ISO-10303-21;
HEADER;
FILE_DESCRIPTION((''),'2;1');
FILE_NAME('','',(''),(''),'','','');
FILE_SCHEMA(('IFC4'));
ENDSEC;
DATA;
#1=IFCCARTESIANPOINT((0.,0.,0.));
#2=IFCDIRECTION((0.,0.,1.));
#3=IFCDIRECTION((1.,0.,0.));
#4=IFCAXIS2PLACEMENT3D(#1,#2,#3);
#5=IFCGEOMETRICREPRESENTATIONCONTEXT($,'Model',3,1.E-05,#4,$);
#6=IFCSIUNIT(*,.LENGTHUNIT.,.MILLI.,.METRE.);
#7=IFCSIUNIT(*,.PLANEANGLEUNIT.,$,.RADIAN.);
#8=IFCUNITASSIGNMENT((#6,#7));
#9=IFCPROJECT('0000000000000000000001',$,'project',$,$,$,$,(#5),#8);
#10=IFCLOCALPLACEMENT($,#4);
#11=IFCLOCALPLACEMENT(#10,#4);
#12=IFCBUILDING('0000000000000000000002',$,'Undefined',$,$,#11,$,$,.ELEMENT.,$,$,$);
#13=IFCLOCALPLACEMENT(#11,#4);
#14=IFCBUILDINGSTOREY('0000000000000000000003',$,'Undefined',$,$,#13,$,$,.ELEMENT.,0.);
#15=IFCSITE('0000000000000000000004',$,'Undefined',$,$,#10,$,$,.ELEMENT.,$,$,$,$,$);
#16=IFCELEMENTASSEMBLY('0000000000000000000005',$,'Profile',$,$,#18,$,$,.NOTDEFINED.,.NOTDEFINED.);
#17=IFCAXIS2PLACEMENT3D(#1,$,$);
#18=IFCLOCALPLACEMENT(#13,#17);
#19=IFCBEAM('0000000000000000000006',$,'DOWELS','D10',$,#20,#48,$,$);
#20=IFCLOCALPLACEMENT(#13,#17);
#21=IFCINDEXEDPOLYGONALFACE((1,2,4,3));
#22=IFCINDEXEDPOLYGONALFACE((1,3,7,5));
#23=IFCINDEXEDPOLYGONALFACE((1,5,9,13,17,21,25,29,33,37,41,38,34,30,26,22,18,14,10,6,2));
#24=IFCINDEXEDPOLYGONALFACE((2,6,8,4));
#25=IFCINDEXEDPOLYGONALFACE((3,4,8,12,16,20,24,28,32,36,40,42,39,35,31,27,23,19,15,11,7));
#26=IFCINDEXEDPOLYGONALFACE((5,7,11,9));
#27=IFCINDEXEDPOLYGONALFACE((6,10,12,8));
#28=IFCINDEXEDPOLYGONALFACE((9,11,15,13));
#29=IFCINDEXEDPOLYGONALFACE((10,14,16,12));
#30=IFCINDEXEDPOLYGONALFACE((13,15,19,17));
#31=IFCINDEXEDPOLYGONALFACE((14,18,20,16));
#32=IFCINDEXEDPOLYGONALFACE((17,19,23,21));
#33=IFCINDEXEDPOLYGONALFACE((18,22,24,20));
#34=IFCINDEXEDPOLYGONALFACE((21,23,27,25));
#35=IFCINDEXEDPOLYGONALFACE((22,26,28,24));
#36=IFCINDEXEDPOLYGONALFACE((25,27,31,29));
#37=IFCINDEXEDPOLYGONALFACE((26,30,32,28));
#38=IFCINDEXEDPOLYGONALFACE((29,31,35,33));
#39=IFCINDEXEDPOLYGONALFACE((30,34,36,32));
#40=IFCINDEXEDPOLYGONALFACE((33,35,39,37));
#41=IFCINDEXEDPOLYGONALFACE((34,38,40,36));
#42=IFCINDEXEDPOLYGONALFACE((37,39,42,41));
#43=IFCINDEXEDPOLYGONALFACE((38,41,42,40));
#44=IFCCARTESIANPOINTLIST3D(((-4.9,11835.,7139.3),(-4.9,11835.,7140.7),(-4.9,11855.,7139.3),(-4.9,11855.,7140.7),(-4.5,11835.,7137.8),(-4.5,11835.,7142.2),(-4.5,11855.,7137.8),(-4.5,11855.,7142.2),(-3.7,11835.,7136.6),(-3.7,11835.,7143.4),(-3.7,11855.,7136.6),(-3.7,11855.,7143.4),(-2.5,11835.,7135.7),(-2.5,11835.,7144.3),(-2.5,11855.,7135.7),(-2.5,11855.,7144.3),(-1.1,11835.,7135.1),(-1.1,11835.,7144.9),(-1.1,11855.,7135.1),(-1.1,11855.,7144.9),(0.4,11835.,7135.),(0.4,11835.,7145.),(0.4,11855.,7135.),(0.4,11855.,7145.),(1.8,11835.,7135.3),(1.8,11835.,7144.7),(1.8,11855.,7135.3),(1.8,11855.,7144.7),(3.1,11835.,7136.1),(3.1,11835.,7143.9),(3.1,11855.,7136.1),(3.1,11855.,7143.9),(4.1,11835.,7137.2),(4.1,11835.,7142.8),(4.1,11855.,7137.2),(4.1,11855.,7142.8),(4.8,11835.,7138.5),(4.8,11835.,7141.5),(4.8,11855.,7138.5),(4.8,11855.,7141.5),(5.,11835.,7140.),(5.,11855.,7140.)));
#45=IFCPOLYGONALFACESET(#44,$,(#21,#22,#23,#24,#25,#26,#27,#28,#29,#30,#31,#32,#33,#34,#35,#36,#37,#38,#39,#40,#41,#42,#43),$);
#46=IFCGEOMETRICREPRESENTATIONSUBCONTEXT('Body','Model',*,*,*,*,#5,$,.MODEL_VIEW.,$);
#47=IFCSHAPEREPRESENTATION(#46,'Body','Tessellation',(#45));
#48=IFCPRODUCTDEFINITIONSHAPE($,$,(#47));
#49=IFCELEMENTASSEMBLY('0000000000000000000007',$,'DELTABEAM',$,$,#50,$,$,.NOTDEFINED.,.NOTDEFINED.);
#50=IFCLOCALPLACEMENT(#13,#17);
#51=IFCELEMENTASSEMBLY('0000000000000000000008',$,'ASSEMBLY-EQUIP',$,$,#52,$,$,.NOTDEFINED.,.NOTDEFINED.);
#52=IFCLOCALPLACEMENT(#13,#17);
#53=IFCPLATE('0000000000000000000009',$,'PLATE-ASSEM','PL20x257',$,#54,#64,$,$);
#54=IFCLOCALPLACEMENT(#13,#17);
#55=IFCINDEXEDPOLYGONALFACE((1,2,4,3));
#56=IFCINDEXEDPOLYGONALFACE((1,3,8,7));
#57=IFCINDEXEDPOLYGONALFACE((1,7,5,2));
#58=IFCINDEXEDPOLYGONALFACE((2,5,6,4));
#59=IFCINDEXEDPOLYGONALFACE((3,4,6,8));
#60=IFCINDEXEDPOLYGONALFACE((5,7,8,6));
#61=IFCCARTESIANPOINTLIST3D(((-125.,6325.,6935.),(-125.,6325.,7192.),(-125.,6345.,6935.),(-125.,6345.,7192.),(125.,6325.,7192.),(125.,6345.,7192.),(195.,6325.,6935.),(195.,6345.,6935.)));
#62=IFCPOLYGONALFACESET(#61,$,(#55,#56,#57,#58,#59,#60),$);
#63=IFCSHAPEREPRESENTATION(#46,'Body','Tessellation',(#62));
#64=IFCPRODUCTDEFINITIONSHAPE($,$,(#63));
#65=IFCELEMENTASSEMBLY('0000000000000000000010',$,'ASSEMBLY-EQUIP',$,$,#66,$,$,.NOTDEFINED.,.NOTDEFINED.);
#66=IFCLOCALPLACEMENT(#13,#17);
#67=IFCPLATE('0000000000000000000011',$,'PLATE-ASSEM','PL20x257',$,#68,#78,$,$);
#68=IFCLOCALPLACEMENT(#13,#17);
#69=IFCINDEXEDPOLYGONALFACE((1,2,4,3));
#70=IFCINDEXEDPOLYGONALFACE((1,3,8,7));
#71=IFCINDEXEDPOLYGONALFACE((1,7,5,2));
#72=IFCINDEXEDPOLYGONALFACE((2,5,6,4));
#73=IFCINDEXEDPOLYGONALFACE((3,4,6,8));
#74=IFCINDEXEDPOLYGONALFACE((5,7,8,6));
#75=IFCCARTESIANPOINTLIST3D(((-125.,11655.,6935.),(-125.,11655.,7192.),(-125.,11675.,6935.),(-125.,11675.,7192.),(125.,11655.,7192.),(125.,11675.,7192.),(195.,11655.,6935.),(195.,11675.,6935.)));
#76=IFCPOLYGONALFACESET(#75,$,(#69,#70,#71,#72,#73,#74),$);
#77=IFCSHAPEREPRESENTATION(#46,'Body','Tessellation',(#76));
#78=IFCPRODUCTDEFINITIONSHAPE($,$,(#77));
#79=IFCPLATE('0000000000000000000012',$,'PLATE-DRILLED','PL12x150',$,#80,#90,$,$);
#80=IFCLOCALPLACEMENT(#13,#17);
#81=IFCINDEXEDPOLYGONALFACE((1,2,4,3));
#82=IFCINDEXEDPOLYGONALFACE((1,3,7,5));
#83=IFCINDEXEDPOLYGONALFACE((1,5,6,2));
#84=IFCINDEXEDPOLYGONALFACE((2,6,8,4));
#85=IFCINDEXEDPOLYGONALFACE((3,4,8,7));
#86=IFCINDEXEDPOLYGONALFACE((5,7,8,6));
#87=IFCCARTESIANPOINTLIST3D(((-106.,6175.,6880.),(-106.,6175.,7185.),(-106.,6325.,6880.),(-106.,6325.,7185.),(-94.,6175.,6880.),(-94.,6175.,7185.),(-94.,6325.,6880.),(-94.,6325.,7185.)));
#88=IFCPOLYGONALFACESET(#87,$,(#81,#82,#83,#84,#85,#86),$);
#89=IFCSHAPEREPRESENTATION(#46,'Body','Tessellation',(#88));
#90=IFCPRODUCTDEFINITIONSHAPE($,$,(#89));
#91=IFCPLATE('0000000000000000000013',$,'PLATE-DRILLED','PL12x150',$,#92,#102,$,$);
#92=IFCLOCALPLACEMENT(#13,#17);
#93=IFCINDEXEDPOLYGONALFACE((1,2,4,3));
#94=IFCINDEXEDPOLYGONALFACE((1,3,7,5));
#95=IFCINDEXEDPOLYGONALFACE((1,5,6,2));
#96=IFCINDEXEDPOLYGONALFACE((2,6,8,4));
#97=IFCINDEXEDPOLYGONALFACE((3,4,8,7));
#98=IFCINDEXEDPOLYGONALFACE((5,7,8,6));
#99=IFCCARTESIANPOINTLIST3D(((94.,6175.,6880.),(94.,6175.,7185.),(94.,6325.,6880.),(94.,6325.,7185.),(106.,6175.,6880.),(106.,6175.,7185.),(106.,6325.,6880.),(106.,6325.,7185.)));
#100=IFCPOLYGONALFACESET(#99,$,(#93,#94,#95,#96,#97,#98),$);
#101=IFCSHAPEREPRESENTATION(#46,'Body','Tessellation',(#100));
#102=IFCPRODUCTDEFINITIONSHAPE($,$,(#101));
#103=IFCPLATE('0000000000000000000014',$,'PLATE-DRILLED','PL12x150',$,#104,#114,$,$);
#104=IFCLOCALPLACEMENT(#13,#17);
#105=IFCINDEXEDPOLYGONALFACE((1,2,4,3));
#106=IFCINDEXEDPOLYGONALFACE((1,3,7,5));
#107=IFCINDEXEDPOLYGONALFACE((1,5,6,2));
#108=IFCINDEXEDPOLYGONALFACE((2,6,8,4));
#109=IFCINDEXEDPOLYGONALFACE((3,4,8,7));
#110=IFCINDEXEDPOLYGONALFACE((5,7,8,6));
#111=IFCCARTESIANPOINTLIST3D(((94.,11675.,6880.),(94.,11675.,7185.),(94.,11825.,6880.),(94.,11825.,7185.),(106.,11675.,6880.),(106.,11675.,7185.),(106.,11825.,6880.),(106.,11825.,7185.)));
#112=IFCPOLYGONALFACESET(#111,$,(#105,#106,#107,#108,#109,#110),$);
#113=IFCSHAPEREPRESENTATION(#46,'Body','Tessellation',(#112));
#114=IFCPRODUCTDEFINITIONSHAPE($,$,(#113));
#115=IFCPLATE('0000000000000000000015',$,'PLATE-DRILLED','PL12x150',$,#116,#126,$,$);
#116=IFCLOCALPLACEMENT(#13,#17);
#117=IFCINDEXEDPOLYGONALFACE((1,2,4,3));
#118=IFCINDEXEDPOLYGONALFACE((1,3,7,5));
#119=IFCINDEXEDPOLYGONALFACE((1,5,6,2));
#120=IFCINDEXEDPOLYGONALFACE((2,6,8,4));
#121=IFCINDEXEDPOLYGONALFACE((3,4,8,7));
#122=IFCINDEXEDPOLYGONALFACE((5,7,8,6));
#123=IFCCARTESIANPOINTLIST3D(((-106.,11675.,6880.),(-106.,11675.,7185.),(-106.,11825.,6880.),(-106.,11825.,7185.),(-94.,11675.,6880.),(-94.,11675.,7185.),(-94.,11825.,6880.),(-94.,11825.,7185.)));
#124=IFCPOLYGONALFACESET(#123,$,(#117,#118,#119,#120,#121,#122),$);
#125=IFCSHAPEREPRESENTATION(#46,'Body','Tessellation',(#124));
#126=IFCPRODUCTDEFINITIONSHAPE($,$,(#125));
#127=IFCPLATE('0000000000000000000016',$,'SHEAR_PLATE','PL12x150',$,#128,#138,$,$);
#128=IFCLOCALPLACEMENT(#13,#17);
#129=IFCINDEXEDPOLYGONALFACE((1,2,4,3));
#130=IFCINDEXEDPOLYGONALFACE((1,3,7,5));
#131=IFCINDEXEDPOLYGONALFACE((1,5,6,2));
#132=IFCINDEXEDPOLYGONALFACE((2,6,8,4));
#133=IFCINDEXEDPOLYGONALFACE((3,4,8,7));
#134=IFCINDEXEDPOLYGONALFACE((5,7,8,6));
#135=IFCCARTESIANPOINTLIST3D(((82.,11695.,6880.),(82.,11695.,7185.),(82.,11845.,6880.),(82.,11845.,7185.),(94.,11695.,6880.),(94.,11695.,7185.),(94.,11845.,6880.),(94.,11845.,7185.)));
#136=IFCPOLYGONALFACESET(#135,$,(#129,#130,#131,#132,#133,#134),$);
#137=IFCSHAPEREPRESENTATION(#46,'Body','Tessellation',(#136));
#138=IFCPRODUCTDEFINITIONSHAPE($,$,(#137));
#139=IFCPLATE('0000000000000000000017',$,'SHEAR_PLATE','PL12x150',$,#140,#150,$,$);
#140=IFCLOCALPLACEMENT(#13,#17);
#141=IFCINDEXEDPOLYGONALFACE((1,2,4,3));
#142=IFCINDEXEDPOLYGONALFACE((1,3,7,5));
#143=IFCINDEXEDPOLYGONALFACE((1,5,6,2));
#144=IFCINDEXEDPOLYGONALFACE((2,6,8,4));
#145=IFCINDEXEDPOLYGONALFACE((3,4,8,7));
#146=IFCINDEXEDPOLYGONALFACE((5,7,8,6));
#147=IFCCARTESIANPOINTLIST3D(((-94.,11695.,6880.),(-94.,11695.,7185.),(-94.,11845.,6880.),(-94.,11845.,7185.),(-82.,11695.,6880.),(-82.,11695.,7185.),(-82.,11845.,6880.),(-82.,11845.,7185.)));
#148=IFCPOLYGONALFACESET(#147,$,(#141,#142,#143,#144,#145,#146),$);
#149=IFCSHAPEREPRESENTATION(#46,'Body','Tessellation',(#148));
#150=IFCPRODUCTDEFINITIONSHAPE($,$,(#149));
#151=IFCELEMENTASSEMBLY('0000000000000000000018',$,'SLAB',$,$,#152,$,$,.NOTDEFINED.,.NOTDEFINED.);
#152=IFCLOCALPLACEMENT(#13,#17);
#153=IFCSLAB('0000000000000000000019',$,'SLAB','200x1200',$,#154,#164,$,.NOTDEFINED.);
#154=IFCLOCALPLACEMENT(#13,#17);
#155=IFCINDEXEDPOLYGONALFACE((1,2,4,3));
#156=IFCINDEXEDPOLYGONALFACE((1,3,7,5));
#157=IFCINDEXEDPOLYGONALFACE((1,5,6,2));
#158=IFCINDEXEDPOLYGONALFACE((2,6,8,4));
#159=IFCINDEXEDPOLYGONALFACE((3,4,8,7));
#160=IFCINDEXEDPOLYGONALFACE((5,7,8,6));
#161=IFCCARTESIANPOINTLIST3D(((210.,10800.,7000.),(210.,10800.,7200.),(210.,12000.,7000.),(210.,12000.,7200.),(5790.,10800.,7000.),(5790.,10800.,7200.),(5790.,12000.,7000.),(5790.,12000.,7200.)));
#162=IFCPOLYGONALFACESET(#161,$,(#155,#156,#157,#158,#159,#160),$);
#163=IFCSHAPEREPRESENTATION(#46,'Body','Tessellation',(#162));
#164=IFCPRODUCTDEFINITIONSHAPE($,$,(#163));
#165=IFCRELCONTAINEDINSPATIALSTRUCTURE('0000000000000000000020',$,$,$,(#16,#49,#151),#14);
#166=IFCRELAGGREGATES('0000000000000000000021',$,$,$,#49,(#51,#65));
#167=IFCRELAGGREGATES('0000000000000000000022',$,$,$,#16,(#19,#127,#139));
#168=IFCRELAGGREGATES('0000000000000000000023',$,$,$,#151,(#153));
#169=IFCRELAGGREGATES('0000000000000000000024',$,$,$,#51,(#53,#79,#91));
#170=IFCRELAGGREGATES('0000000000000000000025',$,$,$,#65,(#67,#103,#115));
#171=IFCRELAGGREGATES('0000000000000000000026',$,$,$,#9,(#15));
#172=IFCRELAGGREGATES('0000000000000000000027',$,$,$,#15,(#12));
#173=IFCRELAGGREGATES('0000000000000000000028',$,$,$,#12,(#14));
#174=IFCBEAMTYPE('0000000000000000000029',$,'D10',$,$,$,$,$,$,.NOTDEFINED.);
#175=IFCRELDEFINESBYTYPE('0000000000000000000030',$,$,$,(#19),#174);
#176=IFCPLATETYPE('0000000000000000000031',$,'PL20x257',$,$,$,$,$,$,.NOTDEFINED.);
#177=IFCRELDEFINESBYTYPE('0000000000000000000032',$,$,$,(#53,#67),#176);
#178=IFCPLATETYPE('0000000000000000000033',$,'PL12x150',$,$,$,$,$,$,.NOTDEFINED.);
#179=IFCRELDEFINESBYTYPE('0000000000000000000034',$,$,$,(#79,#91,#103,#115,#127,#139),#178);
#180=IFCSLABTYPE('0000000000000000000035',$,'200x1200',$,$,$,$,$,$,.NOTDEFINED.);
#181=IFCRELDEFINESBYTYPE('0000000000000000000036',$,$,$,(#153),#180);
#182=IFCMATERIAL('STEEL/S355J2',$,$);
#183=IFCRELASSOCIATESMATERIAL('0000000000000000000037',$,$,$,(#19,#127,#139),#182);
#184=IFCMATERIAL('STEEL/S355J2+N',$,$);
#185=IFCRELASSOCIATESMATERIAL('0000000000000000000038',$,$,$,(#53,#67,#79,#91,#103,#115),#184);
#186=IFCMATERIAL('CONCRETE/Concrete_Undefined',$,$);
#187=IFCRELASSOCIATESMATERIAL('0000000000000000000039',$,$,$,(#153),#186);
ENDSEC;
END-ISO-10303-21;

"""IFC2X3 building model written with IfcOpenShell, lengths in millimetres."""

from ifc_helpers import new_model, si_unit, frame, origin_with_axes, origin_2d_with_axis, place, context, subcontext, project, spatial, polyline, circle, outline, extrude, material, type_object, element, aggregate, save


model = new_model("IFC2X3")

# Units and contexts
model_context = context("Model", 3, precision=1e-05, world=origin_with_axes())
body_context = subcontext(model_context, "Body", "Model", "MODEL_VIEW")
ifc_project = project(units=[si_unit("LENGTHUNIT", "METRE", prefix="MILLI"), si_unit("PLANEANGLEUNIT", "RADIAN")], contexts=[model_context])

# Site, building, storey
site_placement = place(None, origin_with_axes())
site = spatial("IfcSite", under=ifc_project, at=site_placement, Name="Undefined", CompositionType="ELEMENT")
building_placement = place(site_placement, origin_with_axes())
building = spatial("IfcBuilding", under=site, at=building_placement, Name="Undefined", CompositionType="ELEMENT")
storey_placement = place(building_placement, origin_with_axes())
storey = spatial("IfcBuildingStorey", under=building, at=storey_placement, Name="Undefined", CompositionType="ELEMENT", Elevation=0.0)

# Element assembly, beam
assembly_1_placement = place(storey_placement, origin_with_axes())
assembly_1 = element("IfcElementAssembly", 1, at=assembly_1_placement, inside=storey, Name="Profile", AssemblyPlace="NOTDEFINED", PredefinedType="NOTDEFINED")
ifc_material_1 = material(Name="STEEL/S355J2")
beam_type_1 = type_object("IfcBeamType", Name="D10", PredefinedType="NOTDEFINED")
beam_1_placement = place(assembly_1_placement, frame((0.0, 11835.0, 7140.0), z_axis=(0.0, 0.0, 1.0), x_axis=(0.0, 1.0, 0.0)))
beam_1 = element("IfcBeam", 2, at=beam_1_placement, type_object=beam_type_1, material=ifc_material_1, Name="DOWELS", Description="D10", context=body_context, shape_type="SweptSolid", body=[
    extrude(circle(Radius=5.0, at=origin_2d_with_axis()), frame((20.0, 0.0, 0.0), z_axis=(-1.0, 0.0, 0.0), x_axis=(0.0, -1.0, 0.0)), (0.0, 0.0, 1.0), 20.0),
])

# Element assemblies, plates
assembly_2_placement = place(storey_placement, origin_with_axes())
assembly_2 = element("IfcElementAssembly", 3, at=assembly_2_placement, inside=storey, Name="DELTABEAM", AssemblyPlace="NOTDEFINED", PredefinedType="NOTDEFINED")
assembly_3_placement = place(assembly_2_placement, origin_with_axes())
assembly_3 = element("IfcElementAssembly", 4, at=assembly_3_placement, Name="ASSEMBLY-EQUIP", AssemblyPlace="NOTDEFINED", PredefinedType="NOTDEFINED")
ifc_material_2 = material(Name="STEEL/S355J2+N")
plate_type_1 = type_object("IfcPlateType", Name="PL20x257", PredefinedType="NOTDEFINED")
plate_1_placement = place(assembly_3_placement, frame((195.0, 6335.0, 6935.0), z_axis=(0.0, 1.0, 0.0), x_axis=(-1.0, 0.0, 0.0)))
plate_1 = element("IfcPlate", 5, at=plate_1_placement, type_object=plate_type_1, material=ifc_material_2, Name="PLATE-ASSEM", Description="PL20x257", context=body_context, shape_type="SweptSolid", body=[
    extrude(outline(polyline([(0.0, 0.0), (320.0, 0.0), (320.0, 257.0), (70.0, 257.0), (0.0, 0.0)])), frame((0.0, 0.0, -10.0), z_axis=(0.0, 0.0, 1.0), x_axis=(1.0, 0.0, 0.0)), (0.0, 0.0, 1.0), 20.0),
])
assembly_4_placement = place(assembly_2_placement, origin_with_axes())
assembly_4 = element("IfcElementAssembly", 6, at=assembly_4_placement, Name="ASSEMBLY-EQUIP", AssemblyPlace="NOTDEFINED", PredefinedType="NOTDEFINED")
aggregate(assembly_2, [assembly_3, assembly_4])
plate_2_placement = place(assembly_4_placement, frame((-125.0, 11665.0, 6935.0), z_axis=(0.0, -1.0, 0.0), x_axis=(1.0, 0.0, 0.0)))
plate_2 = element("IfcPlate", 7, at=plate_2_placement, type_object=plate_type_1, material=ifc_material_2, Name="PLATE-ASSEM", Description="PL20x257", context=body_context, shape_type="SweptSolid", body=[
    extrude(outline(polyline([(0.0, 0.0), (320.0, 0.0), (250.0, 257.0), (0.0, 257.0), (0.0, 0.0)])), frame((0.0, 0.0, -10.0), z_axis=(0.0, 0.0, 1.0), x_axis=(1.0, 0.0, 0.0)), (0.0, 0.0, 1.0), 20.0),
])
plate_type_2 = type_object("IfcPlateType", Name="PL12x150", PredefinedType="NOTDEFINED")
plate_3_placement = place(assembly_3_placement, frame((-100.0, 6325.0, 7185.0), z_axis=(1.0, 0.0, 0.0), x_axis=(0.0, -1.0, 0.0)))
plate_3 = element("IfcPlate", 8, at=plate_3_placement, type_object=plate_type_2, material=ifc_material_2, Name="PLATE-DRILLED", Description="PL12x150", context=body_context, shape_type="SweptSolid", body=[
    extrude(outline(polyline([(0.0, 0.0), (150.0, 0.0), (150.0, 0.0), (150.0, 305.0), (150.0, 305.0), (0.0, 305.0), (0.0, 305.0), (0.0, 0.0)])), frame((0.0, 0.0, -6.0), z_axis=(0.0, 0.0, 1.0), x_axis=(1.0, 0.0, 0.0)), (0.0, 0.0, 1.0), 12.0),
])
plate_4_placement = place(assembly_3_placement, frame((100.0, 6325.0, 7185.0), z_axis=(1.0, 0.0, 0.0), x_axis=(0.0, -1.0, 0.0)))
plate_4 = element("IfcPlate", 9, at=plate_4_placement, type_object=plate_type_2, material=ifc_material_2, Name="PLATE-DRILLED", Description="PL12x150", context=body_context, shape_type="SweptSolid", body=[
    extrude(outline(polyline([(0.0, 0.0), (150.0, 0.0), (150.0, 0.0), (150.0, 305.0), (150.0, 305.0), (0.0, 305.0), (0.0, 305.0), (0.0, 0.0)])), frame((0.0, 0.0, -6.0), z_axis=(0.0, 0.0, 1.0), x_axis=(1.0, 0.0, 0.0)), (0.0, 0.0, 1.0), 12.0),
])
plate_5_placement = place(assembly_4_placement, frame((100.0, 11675.0, 7185.0), z_axis=(-1.0, 0.0, 0.0), x_axis=(0.0, 1.0, 0.0)))
plate_5 = element("IfcPlate", 10, at=plate_5_placement, type_object=plate_type_2, material=ifc_material_2, Name="PLATE-DRILLED", Description="PL12x150", context=body_context, shape_type="SweptSolid", body=[
    extrude(outline(polyline([(0.0, 0.0), (150.0, 0.0), (150.0, 0.0), (150.0, 305.0), (150.0, 305.0), (0.0, 305.0), (0.0, 305.0), (0.0, 0.0)])), frame((0.0, 0.0, -6.0), z_axis=(0.0, 0.0, 1.0), x_axis=(1.0, 0.0, 0.0)), (0.0, 0.0, 1.0), 12.0),
])
plate_6_placement = place(assembly_4_placement, frame((-100.0, 11675.0, 7185.0), z_axis=(-1.0, 0.0, 0.0), x_axis=(0.0, 1.0, 0.0)))
plate_6 = element("IfcPlate", 11, at=plate_6_placement, type_object=plate_type_2, material=ifc_material_2, Name="PLATE-DRILLED", Description="PL12x150", context=body_context, shape_type="SweptSolid", body=[
    extrude(outline(polyline([(0.0, 0.0), (150.0, 0.0), (150.0, 0.0), (150.0, 305.0), (150.0, 305.0), (0.0, 305.0), (0.0, 305.0), (0.0, 0.0)])), frame((0.0, 0.0, -6.0), z_axis=(0.0, 0.0, 1.0), x_axis=(1.0, 0.0, 0.0)), (0.0, 0.0, 1.0), 12.0),
])

# Plates
plate_7_placement = place(assembly_1_placement, frame((88.0, 11845.0, 7185.0), z_axis=(1.0, 0.0, 0.0), x_axis=(0.0, -1.0, 0.0)))
plate_7 = element("IfcPlate", 12, at=plate_7_placement, type_object=plate_type_2, material=ifc_material_1, Name="SHEAR_PLATE", Description="PL12x150", context=body_context, shape_type="SweptSolid", body=[
    extrude(outline(polyline([(0.0, 0.0), (150.0, 0.0), (150.0, 0.0), (150.0, 305.0), (150.0, 305.0), (0.0, 305.0), (0.0, 305.0), (0.0, 0.0)])), frame((0.0, 0.0, -6.0), z_axis=(0.0, 0.0, 1.0), x_axis=(1.0, 0.0, 0.0)), (0.0, 0.0, 1.0), 12.0),
])
plate_8_placement = place(assembly_1_placement, frame((-88.0, 11845.0, 7185.0), z_axis=(1.0, 0.0, 0.0), x_axis=(0.0, -1.0, 0.0)))
plate_8 = element("IfcPlate", 13, at=plate_8_placement, type_object=plate_type_2, material=ifc_material_1, Name="SHEAR_PLATE", Description="PL12x150", context=body_context, shape_type="SweptSolid", body=[
    extrude(outline(polyline([(0.0, 0.0), (150.0, 0.0), (150.0, 0.0), (150.0, 305.0), (150.0, 305.0), (0.0, 305.0), (0.0, 305.0), (0.0, 0.0)])), frame((0.0, 0.0, -6.0), z_axis=(0.0, 0.0, 1.0), x_axis=(1.0, 0.0, 0.0)), (0.0, 0.0, 1.0), 12.0),
])
aggregate(assembly_1, [beam_1, plate_7, plate_8])

# Element assembly, slab
assembly_5_placement = place(storey_placement, origin_with_axes())
assembly_5 = element("IfcElementAssembly", 14, at=assembly_5_placement, inside=storey, Name="SLAB", AssemblyPlace="NOTDEFINED", PredefinedType="NOTDEFINED")
ifc_material_3 = material(Name="CONCRETE/Concrete_Undefined")
slab_type = type_object("IfcSlabType", Name="200x1200", PredefinedType="NOTDEFINED")
slab_placement = place(assembly_5_placement, frame((5790.0, 10800.0, 7100.0), z_axis=(0.0, 0.0, 1.0), x_axis=(0.0, 1.0, 0.0)))
slab = element("IfcSlab", 15, at=slab_placement, type_object=slab_type, material=ifc_material_3, Name="SLAB", Description="200x1200", PredefinedType="NOTDEFINED", context=body_context, shape_type="SweptSolid", body=[
    extrude(outline(polyline([(0.0, 0.0), (1200.0, 0.0), (1200.0, 5580.0), (0.0, 5580.0), (0.0, 0.0)])), frame((0.0, 0.0, -100.0), z_axis=(0.0, 0.0, 1.0), x_axis=(1.0, 0.0, 0.0)), (0.0, 0.0, 1.0), 200.0),
])
aggregate(assembly_5, [slab])

aggregate(assembly_3, [plate_1, plate_3, plate_4])
aggregate(assembly_4, [plate_2, plate_5, plate_6])

save(model, "model.ifc")
